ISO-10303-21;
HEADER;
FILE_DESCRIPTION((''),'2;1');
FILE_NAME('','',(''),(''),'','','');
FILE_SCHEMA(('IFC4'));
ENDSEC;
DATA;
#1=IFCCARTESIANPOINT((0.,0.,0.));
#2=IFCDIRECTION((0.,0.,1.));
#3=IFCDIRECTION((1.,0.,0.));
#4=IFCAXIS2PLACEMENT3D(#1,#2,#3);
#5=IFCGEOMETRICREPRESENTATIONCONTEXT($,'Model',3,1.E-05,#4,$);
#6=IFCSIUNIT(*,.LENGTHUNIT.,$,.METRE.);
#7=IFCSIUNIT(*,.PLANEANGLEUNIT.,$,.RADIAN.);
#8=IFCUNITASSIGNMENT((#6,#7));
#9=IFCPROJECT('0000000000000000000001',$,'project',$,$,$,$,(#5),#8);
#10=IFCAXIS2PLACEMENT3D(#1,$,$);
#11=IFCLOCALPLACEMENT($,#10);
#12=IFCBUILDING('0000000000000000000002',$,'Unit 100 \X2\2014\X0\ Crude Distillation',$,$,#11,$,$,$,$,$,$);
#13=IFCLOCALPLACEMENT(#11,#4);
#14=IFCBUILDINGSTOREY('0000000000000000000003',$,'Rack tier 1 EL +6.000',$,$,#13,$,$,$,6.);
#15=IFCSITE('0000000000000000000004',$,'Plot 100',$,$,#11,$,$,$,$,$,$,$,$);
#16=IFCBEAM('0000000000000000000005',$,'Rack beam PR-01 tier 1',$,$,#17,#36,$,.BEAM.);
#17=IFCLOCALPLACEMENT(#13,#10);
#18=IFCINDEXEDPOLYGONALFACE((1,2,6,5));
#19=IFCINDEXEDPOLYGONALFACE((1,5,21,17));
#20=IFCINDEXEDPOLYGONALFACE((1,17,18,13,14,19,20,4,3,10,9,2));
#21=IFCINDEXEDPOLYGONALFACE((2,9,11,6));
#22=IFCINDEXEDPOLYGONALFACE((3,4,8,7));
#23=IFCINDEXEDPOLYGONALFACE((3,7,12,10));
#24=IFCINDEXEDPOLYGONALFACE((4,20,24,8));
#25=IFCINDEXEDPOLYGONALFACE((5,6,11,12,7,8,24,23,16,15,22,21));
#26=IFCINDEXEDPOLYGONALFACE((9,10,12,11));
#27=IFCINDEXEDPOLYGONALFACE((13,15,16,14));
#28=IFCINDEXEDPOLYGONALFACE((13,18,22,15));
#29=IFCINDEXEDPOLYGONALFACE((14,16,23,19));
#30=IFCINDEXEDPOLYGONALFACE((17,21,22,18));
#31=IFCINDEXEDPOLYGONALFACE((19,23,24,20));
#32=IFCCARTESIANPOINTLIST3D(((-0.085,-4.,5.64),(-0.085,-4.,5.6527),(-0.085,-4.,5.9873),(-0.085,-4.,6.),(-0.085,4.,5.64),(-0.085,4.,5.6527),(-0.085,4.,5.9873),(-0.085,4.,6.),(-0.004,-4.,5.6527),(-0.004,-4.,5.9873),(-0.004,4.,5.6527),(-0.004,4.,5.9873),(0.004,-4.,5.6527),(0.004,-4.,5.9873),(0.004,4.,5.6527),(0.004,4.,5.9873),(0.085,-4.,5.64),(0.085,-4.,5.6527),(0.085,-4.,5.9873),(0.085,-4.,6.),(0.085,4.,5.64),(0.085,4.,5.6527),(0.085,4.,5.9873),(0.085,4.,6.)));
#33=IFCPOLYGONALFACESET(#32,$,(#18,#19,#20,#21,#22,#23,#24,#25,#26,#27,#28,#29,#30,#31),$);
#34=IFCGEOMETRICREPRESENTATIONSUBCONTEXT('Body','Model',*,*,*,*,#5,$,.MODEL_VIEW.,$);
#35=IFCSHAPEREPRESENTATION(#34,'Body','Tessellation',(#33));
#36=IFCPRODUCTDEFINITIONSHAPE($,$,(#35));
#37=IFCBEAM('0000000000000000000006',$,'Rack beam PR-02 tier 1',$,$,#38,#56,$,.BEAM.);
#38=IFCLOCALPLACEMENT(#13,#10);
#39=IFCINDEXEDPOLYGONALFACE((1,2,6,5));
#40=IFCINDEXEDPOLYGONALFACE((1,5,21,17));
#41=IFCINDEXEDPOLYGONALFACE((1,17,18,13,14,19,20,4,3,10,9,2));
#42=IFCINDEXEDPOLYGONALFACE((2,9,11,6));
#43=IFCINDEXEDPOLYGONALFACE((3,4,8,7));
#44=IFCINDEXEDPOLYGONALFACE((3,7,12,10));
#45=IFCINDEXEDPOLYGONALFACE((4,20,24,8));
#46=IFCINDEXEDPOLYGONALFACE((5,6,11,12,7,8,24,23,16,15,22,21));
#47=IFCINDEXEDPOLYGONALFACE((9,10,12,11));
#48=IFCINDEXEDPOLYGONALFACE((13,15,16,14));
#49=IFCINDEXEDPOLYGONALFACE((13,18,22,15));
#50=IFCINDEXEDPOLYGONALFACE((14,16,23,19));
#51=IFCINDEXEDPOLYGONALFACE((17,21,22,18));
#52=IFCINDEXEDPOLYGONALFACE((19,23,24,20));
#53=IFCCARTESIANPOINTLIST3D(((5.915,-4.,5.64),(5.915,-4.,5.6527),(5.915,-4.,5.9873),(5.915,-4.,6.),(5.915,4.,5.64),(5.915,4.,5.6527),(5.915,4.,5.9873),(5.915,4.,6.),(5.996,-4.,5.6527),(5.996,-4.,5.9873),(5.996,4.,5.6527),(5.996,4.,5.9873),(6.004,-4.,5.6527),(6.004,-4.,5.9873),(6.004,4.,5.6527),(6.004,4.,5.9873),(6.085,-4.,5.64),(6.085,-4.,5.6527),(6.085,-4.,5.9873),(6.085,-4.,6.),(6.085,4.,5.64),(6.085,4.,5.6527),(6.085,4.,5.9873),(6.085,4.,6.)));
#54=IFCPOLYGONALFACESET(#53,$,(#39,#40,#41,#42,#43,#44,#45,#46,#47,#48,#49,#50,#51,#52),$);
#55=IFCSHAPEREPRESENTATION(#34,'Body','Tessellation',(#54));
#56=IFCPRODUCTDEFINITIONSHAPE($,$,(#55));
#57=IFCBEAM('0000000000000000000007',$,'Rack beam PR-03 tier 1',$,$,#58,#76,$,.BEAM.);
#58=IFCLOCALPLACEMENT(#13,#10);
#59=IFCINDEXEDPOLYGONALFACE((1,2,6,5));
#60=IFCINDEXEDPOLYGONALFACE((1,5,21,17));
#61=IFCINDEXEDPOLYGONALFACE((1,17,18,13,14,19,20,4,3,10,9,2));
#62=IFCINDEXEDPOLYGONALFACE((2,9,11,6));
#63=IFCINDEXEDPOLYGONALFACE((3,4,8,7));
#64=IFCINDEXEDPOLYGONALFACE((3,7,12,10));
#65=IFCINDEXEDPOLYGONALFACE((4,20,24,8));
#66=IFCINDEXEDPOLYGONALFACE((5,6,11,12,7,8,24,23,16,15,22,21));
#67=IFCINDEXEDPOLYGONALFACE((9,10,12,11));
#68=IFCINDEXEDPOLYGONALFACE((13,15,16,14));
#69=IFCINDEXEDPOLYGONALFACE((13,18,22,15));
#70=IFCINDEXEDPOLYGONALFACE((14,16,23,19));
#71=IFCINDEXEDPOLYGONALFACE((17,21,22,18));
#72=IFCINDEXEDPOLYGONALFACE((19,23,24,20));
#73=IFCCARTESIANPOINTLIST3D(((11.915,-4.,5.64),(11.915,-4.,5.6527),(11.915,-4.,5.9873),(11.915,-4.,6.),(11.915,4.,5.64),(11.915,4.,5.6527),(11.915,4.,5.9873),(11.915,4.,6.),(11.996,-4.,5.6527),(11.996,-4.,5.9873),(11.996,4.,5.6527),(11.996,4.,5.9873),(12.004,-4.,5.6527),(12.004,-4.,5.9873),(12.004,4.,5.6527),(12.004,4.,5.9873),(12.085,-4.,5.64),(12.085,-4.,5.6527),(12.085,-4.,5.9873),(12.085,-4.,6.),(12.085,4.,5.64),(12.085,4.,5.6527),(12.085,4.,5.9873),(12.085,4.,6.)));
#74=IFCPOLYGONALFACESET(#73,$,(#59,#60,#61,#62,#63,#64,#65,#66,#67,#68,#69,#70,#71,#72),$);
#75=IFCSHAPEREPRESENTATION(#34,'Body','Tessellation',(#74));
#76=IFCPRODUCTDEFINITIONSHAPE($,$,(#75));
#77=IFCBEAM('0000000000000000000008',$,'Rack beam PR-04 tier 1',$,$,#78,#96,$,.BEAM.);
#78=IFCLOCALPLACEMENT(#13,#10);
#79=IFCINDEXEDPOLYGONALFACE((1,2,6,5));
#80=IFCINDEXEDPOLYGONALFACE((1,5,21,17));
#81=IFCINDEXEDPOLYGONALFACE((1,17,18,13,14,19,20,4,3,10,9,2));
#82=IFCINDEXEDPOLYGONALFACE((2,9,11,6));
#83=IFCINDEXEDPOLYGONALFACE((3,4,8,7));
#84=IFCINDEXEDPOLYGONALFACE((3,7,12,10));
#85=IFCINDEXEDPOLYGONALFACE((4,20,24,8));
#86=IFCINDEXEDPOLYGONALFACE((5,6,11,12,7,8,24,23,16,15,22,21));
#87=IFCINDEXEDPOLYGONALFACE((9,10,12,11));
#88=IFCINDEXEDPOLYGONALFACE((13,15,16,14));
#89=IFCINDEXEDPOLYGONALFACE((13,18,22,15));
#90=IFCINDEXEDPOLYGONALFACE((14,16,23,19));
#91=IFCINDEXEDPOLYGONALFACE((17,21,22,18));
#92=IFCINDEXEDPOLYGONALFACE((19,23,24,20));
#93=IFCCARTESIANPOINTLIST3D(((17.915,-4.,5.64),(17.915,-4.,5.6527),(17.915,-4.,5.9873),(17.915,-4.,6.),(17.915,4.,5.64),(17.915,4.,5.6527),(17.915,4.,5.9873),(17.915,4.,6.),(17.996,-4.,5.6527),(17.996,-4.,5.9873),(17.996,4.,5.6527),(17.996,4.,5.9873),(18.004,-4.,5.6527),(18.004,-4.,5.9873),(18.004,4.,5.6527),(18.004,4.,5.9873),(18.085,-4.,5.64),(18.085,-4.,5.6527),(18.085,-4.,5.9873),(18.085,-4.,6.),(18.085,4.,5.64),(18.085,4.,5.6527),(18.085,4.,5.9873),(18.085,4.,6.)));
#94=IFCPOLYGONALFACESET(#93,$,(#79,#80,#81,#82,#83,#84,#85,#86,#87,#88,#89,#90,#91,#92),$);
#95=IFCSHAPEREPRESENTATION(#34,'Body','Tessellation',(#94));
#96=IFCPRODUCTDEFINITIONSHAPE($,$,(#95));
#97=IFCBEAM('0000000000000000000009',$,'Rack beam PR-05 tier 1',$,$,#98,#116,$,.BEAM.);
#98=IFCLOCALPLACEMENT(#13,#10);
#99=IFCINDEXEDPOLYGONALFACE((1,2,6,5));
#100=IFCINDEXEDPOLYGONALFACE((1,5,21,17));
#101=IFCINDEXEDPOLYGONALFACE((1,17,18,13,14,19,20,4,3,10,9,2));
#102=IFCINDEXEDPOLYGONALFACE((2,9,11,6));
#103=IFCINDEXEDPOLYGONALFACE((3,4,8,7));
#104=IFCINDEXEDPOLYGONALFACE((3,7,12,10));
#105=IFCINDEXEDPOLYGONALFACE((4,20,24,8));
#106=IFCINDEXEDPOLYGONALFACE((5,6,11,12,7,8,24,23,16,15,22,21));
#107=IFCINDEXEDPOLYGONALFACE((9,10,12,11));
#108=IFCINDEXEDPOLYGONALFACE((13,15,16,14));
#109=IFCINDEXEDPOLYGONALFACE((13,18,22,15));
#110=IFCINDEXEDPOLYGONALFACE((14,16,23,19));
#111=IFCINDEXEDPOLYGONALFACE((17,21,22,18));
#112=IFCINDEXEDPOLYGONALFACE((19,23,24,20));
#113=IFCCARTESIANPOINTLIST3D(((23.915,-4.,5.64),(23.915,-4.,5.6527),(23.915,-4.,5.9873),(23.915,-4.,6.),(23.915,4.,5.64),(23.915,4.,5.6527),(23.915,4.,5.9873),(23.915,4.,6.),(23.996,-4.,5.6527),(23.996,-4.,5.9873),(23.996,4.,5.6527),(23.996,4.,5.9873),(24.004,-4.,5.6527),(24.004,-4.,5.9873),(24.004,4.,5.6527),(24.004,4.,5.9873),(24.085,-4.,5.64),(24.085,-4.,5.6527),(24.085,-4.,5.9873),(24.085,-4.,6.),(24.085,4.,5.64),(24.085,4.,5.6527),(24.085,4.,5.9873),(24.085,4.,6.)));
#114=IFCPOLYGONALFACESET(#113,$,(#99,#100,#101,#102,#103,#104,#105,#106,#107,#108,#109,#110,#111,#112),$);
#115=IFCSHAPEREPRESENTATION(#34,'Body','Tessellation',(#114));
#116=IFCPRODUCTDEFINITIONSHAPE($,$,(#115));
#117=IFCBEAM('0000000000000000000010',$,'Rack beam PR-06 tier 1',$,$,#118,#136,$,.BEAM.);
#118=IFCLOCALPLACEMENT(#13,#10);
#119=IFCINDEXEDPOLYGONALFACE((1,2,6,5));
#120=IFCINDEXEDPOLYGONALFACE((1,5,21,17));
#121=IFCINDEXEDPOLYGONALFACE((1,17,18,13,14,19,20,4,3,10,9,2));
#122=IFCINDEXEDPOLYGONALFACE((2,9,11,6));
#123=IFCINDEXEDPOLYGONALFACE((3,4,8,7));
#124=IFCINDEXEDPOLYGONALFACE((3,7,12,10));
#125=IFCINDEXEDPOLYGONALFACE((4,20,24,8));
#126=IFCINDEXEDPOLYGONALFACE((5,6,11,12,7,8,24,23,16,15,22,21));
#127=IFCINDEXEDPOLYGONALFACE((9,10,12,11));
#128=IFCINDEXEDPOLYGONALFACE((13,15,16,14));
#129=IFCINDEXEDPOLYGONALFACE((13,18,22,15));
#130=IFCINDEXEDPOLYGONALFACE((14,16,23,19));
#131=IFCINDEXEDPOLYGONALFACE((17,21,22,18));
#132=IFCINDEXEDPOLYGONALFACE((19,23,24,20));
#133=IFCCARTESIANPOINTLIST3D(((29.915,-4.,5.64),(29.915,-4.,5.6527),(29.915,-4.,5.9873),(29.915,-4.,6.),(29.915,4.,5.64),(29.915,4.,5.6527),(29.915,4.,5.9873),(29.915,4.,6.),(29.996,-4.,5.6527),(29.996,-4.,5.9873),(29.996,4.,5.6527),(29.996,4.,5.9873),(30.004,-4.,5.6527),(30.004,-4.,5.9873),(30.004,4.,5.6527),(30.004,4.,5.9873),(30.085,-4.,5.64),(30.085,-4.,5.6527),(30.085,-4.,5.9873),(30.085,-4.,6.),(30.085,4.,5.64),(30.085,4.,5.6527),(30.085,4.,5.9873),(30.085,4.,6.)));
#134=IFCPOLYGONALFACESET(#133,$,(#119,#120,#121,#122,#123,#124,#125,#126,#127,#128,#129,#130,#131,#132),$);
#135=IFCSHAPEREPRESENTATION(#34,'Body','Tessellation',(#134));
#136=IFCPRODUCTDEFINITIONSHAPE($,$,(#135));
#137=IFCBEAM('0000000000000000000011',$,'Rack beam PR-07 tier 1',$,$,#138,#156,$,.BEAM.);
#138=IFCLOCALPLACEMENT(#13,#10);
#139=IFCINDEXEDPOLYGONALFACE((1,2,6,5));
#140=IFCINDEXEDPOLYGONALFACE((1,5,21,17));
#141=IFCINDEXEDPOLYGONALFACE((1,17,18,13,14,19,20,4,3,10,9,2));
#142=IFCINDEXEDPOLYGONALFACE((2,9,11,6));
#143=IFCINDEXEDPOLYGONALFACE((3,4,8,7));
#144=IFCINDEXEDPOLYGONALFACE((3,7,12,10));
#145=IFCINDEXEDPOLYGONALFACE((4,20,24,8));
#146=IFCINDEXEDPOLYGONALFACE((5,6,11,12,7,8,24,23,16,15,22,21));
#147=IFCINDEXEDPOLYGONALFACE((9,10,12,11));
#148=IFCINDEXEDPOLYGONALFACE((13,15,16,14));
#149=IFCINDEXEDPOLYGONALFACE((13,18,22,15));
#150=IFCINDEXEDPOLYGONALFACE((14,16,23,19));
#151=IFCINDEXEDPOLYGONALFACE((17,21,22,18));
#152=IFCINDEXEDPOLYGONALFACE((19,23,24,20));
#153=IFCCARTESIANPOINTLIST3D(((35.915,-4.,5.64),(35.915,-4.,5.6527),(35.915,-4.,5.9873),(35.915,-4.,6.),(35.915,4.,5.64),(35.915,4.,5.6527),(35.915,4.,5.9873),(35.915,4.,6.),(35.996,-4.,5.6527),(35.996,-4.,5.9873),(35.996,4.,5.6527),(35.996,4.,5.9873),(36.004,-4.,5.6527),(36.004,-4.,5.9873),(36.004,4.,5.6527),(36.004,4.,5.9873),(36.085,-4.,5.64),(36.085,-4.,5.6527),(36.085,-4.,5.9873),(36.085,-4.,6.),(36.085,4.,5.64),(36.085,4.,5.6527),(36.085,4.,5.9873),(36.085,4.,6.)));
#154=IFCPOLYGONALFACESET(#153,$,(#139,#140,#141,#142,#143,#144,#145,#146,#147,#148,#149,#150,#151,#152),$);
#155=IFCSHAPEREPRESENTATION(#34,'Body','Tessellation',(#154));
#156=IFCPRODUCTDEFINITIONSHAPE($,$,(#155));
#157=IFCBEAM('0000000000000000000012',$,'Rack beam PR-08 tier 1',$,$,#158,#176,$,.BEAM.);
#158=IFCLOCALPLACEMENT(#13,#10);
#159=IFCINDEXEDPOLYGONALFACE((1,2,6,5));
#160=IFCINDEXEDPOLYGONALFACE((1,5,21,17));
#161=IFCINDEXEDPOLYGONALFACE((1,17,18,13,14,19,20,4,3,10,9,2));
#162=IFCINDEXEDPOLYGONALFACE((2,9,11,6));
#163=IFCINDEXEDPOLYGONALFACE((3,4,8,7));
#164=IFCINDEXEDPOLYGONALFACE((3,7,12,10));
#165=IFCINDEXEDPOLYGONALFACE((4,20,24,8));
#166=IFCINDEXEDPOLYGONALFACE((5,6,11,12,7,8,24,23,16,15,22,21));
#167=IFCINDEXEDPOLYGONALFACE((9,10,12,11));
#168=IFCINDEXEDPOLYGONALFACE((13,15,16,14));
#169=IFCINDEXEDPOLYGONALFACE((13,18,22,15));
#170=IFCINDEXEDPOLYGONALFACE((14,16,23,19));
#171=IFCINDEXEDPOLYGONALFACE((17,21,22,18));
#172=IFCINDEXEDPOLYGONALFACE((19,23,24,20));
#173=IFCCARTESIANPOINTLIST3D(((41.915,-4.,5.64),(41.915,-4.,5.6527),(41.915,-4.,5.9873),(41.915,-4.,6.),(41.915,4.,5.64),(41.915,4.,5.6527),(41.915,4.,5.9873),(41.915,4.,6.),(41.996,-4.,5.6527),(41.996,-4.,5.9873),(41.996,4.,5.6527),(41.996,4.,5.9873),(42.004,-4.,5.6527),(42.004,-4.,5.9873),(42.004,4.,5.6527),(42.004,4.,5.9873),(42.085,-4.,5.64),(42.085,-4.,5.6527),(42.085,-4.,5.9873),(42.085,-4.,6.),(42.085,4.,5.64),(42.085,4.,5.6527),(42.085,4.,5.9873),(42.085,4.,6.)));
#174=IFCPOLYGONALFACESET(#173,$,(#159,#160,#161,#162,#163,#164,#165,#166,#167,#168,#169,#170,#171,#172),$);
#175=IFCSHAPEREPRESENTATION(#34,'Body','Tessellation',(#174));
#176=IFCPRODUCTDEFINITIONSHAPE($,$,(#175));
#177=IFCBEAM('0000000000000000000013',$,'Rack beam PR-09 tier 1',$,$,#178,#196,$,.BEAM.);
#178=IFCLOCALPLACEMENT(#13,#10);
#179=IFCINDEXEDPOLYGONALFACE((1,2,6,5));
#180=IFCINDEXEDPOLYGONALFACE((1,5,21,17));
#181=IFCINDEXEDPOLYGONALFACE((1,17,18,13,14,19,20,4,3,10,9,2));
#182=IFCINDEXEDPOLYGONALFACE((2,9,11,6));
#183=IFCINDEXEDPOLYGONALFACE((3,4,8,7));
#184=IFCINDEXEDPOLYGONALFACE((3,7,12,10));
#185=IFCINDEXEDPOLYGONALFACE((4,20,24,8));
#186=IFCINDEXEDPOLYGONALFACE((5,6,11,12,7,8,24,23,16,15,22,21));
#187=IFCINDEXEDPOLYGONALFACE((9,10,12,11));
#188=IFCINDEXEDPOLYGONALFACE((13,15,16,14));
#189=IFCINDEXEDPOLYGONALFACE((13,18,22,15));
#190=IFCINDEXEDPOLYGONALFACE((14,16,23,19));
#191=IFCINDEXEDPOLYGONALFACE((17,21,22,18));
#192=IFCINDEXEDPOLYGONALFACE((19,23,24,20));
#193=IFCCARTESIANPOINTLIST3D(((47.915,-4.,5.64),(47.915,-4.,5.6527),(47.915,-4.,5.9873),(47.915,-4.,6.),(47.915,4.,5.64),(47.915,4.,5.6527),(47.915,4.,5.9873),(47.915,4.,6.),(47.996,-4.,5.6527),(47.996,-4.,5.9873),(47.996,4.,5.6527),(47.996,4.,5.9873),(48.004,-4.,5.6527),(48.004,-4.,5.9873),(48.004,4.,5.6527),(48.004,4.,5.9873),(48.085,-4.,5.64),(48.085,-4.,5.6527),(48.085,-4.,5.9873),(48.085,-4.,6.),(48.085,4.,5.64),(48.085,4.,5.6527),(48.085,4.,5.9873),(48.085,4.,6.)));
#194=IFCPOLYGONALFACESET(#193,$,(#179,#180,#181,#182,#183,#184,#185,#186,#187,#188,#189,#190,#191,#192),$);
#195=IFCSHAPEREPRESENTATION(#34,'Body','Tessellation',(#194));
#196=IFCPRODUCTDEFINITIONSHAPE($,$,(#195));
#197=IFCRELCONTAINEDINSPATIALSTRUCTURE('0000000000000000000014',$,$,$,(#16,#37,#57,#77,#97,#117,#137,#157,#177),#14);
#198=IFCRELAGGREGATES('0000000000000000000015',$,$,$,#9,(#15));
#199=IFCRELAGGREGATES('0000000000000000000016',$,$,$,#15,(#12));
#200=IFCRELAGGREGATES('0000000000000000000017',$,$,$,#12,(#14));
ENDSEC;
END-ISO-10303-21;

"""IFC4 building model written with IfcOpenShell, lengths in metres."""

from ifc_helpers import new_model, si_unit, frame, origin, origin_with_axes, origin_2d, place, context, subcontext, project, spatial, i_section, extrude, element, save


model = new_model("IFC4")

# Units and contexts
model_context = context("Model", 3, precision=1e-05, world=origin_with_axes())
body_context = subcontext(model_context, "Body", "Model", "MODEL_VIEW")
ifc_project = project(units=[si_unit("LENGTHUNIT", "METRE"), si_unit("PLANEANGLEUNIT", "RADIAN")], contexts=[model_context])

# Site, building, storey
placement = place(None, origin())
site = spatial("IfcSite", under=ifc_project, at=placement, Name="Plot 100")
building = spatial("IfcBuilding", under=site, at=placement, Name="Unit 100 — Crude Distillation")
storey_placement = place(placement, origin_with_axes())
storey = spatial("IfcBuildingStorey", under=building, at=storey_placement, Name="Rack tier 1 EL +6.000", Elevation=6.0)

# Beams
beam_1_placement = place(storey_placement, origin_with_axes())
element("IfcBeam", 1, at=beam_1_placement, inside=storey, Name="Rack beam PR-01 tier 1", PredefinedType="BEAM", context=body_context, shape_type="SweptSolid", body=[
    extrude(i_section(OverallWidth=0.17, OverallDepth=0.36, WebThickness=0.008, FlangeThickness=0.0127, at=origin_2d()), frame((0.0, -4.0, 5.82), z_axis=(0.0, 1.0, 0.0), x_axis=(-1.0, 0.0, 0.0)), (0.0, 0.0, 1.0), 8.0),
])
beam_2_placement = place(storey_placement, origin_with_axes())
element("IfcBeam", 2, at=beam_2_placement, inside=storey, Name="Rack beam PR-02 tier 1", PredefinedType="BEAM", context=body_context, shape_type="SweptSolid", body=[
    extrude(i_section(OverallWidth=0.17, OverallDepth=0.36, WebThickness=0.008, FlangeThickness=0.0127, at=origin_2d()), frame((6.0, -4.0, 5.82), z_axis=(0.0, 1.0, 0.0), x_axis=(-1.0, 0.0, 0.0)), (0.0, 0.0, 1.0), 8.0),
])
beam_3_placement = place(storey_placement, origin_with_axes())
element("IfcBeam", 3, at=beam_3_placement, inside=storey, Name="Rack beam PR-03 tier 1", PredefinedType="BEAM", context=body_context, shape_type="SweptSolid", body=[
    extrude(i_section(OverallWidth=0.17, OverallDepth=0.36, WebThickness=0.008, FlangeThickness=0.0127, at=origin_2d()), frame((12.0, -4.0, 5.82), z_axis=(0.0, 1.0, 0.0), x_axis=(-1.0, 0.0, 0.0)), (0.0, 0.0, 1.0), 8.0),
])
beam_4_placement = place(storey_placement, origin_with_axes())
element("IfcBeam", 4, at=beam_4_placement, inside=storey, Name="Rack beam PR-04 tier 1", PredefinedType="BEAM", context=body_context, shape_type="SweptSolid", body=[
    extrude(i_section(OverallWidth=0.17, OverallDepth=0.36, WebThickness=0.008, FlangeThickness=0.0127, at=origin_2d()), frame((18.0, -4.0, 5.82), z_axis=(0.0, 1.0, 0.0), x_axis=(-1.0, 0.0, 0.0)), (0.0, 0.0, 1.0), 8.0),
])
beam_5_placement = place(storey_placement, origin_with_axes())
element("IfcBeam", 5, at=beam_5_placement, inside=storey, Name="Rack beam PR-05 tier 1", PredefinedType="BEAM", context=body_context, shape_type="SweptSolid", body=[
    extrude(i_section(OverallWidth=0.17, OverallDepth=0.36, WebThickness=0.008, FlangeThickness=0.0127, at=origin_2d()), frame((24.0, -4.0, 5.82), z_axis=(0.0, 1.0, 0.0), x_axis=(-1.0, 0.0, 0.0)), (0.0, 0.0, 1.0), 8.0),
])
beam_6_placement = place(storey_placement, origin_with_axes())
element("IfcBeam", 6, at=beam_6_placement, inside=storey, Name="Rack beam PR-06 tier 1", PredefinedType="BEAM", context=body_context, shape_type="SweptSolid", body=[
    extrude(i_section(OverallWidth=0.17, OverallDepth=0.36, WebThickness=0.008, FlangeThickness=0.0127, at=origin_2d()), frame((30.0, -4.0, 5.82), z_axis=(0.0, 1.0, 0.0), x_axis=(-1.0, 0.0, 0.0)), (0.0, 0.0, 1.0), 8.0),
])
beam_7_placement = place(storey_placement, origin_with_axes())
element("IfcBeam", 7, at=beam_7_placement, inside=storey, Name="Rack beam PR-07 tier 1", PredefinedType="BEAM", context=body_context, shape_type="SweptSolid", body=[
    extrude(i_section(OverallWidth=0.17, OverallDepth=0.36, WebThickness=0.008, FlangeThickness=0.0127, at=origin_2d()), frame((36.0, -4.0, 5.82), z_axis=(0.0, 1.0, 0.0), x_axis=(-1.0, 0.0, 0.0)), (0.0, 0.0, 1.0), 8.0),
])
beam_8_placement = place(storey_placement, origin_with_axes())
element("IfcBeam", 8, at=beam_8_placement, inside=storey, Name="Rack beam PR-08 tier 1", PredefinedType="BEAM", context=body_context, shape_type="SweptSolid", body=[
    extrude(i_section(OverallWidth=0.17, OverallDepth=0.36, WebThickness=0.008, FlangeThickness=0.0127, at=origin_2d()), frame((42.0, -4.0, 5.82), z_axis=(0.0, 1.0, 0.0), x_axis=(-1.0, 0.0, 0.0)), (0.0, 0.0, 1.0), 8.0),
])
beam_9_placement = place(storey_placement, origin_with_axes())
element("IfcBeam", 9, at=beam_9_placement, inside=storey, Name="Rack beam PR-09 tier 1", PredefinedType="BEAM", context=body_context, shape_type="SweptSolid", body=[
    extrude(i_section(OverallWidth=0.17, OverallDepth=0.36, WebThickness=0.008, FlangeThickness=0.0127, at=origin_2d()), frame((48.0, -4.0, 5.82), z_axis=(0.0, 1.0, 0.0), x_axis=(-1.0, 0.0, 0.0)), (0.0, 0.0, 1.0), 8.0),
])

save(model, "model.ifc")
